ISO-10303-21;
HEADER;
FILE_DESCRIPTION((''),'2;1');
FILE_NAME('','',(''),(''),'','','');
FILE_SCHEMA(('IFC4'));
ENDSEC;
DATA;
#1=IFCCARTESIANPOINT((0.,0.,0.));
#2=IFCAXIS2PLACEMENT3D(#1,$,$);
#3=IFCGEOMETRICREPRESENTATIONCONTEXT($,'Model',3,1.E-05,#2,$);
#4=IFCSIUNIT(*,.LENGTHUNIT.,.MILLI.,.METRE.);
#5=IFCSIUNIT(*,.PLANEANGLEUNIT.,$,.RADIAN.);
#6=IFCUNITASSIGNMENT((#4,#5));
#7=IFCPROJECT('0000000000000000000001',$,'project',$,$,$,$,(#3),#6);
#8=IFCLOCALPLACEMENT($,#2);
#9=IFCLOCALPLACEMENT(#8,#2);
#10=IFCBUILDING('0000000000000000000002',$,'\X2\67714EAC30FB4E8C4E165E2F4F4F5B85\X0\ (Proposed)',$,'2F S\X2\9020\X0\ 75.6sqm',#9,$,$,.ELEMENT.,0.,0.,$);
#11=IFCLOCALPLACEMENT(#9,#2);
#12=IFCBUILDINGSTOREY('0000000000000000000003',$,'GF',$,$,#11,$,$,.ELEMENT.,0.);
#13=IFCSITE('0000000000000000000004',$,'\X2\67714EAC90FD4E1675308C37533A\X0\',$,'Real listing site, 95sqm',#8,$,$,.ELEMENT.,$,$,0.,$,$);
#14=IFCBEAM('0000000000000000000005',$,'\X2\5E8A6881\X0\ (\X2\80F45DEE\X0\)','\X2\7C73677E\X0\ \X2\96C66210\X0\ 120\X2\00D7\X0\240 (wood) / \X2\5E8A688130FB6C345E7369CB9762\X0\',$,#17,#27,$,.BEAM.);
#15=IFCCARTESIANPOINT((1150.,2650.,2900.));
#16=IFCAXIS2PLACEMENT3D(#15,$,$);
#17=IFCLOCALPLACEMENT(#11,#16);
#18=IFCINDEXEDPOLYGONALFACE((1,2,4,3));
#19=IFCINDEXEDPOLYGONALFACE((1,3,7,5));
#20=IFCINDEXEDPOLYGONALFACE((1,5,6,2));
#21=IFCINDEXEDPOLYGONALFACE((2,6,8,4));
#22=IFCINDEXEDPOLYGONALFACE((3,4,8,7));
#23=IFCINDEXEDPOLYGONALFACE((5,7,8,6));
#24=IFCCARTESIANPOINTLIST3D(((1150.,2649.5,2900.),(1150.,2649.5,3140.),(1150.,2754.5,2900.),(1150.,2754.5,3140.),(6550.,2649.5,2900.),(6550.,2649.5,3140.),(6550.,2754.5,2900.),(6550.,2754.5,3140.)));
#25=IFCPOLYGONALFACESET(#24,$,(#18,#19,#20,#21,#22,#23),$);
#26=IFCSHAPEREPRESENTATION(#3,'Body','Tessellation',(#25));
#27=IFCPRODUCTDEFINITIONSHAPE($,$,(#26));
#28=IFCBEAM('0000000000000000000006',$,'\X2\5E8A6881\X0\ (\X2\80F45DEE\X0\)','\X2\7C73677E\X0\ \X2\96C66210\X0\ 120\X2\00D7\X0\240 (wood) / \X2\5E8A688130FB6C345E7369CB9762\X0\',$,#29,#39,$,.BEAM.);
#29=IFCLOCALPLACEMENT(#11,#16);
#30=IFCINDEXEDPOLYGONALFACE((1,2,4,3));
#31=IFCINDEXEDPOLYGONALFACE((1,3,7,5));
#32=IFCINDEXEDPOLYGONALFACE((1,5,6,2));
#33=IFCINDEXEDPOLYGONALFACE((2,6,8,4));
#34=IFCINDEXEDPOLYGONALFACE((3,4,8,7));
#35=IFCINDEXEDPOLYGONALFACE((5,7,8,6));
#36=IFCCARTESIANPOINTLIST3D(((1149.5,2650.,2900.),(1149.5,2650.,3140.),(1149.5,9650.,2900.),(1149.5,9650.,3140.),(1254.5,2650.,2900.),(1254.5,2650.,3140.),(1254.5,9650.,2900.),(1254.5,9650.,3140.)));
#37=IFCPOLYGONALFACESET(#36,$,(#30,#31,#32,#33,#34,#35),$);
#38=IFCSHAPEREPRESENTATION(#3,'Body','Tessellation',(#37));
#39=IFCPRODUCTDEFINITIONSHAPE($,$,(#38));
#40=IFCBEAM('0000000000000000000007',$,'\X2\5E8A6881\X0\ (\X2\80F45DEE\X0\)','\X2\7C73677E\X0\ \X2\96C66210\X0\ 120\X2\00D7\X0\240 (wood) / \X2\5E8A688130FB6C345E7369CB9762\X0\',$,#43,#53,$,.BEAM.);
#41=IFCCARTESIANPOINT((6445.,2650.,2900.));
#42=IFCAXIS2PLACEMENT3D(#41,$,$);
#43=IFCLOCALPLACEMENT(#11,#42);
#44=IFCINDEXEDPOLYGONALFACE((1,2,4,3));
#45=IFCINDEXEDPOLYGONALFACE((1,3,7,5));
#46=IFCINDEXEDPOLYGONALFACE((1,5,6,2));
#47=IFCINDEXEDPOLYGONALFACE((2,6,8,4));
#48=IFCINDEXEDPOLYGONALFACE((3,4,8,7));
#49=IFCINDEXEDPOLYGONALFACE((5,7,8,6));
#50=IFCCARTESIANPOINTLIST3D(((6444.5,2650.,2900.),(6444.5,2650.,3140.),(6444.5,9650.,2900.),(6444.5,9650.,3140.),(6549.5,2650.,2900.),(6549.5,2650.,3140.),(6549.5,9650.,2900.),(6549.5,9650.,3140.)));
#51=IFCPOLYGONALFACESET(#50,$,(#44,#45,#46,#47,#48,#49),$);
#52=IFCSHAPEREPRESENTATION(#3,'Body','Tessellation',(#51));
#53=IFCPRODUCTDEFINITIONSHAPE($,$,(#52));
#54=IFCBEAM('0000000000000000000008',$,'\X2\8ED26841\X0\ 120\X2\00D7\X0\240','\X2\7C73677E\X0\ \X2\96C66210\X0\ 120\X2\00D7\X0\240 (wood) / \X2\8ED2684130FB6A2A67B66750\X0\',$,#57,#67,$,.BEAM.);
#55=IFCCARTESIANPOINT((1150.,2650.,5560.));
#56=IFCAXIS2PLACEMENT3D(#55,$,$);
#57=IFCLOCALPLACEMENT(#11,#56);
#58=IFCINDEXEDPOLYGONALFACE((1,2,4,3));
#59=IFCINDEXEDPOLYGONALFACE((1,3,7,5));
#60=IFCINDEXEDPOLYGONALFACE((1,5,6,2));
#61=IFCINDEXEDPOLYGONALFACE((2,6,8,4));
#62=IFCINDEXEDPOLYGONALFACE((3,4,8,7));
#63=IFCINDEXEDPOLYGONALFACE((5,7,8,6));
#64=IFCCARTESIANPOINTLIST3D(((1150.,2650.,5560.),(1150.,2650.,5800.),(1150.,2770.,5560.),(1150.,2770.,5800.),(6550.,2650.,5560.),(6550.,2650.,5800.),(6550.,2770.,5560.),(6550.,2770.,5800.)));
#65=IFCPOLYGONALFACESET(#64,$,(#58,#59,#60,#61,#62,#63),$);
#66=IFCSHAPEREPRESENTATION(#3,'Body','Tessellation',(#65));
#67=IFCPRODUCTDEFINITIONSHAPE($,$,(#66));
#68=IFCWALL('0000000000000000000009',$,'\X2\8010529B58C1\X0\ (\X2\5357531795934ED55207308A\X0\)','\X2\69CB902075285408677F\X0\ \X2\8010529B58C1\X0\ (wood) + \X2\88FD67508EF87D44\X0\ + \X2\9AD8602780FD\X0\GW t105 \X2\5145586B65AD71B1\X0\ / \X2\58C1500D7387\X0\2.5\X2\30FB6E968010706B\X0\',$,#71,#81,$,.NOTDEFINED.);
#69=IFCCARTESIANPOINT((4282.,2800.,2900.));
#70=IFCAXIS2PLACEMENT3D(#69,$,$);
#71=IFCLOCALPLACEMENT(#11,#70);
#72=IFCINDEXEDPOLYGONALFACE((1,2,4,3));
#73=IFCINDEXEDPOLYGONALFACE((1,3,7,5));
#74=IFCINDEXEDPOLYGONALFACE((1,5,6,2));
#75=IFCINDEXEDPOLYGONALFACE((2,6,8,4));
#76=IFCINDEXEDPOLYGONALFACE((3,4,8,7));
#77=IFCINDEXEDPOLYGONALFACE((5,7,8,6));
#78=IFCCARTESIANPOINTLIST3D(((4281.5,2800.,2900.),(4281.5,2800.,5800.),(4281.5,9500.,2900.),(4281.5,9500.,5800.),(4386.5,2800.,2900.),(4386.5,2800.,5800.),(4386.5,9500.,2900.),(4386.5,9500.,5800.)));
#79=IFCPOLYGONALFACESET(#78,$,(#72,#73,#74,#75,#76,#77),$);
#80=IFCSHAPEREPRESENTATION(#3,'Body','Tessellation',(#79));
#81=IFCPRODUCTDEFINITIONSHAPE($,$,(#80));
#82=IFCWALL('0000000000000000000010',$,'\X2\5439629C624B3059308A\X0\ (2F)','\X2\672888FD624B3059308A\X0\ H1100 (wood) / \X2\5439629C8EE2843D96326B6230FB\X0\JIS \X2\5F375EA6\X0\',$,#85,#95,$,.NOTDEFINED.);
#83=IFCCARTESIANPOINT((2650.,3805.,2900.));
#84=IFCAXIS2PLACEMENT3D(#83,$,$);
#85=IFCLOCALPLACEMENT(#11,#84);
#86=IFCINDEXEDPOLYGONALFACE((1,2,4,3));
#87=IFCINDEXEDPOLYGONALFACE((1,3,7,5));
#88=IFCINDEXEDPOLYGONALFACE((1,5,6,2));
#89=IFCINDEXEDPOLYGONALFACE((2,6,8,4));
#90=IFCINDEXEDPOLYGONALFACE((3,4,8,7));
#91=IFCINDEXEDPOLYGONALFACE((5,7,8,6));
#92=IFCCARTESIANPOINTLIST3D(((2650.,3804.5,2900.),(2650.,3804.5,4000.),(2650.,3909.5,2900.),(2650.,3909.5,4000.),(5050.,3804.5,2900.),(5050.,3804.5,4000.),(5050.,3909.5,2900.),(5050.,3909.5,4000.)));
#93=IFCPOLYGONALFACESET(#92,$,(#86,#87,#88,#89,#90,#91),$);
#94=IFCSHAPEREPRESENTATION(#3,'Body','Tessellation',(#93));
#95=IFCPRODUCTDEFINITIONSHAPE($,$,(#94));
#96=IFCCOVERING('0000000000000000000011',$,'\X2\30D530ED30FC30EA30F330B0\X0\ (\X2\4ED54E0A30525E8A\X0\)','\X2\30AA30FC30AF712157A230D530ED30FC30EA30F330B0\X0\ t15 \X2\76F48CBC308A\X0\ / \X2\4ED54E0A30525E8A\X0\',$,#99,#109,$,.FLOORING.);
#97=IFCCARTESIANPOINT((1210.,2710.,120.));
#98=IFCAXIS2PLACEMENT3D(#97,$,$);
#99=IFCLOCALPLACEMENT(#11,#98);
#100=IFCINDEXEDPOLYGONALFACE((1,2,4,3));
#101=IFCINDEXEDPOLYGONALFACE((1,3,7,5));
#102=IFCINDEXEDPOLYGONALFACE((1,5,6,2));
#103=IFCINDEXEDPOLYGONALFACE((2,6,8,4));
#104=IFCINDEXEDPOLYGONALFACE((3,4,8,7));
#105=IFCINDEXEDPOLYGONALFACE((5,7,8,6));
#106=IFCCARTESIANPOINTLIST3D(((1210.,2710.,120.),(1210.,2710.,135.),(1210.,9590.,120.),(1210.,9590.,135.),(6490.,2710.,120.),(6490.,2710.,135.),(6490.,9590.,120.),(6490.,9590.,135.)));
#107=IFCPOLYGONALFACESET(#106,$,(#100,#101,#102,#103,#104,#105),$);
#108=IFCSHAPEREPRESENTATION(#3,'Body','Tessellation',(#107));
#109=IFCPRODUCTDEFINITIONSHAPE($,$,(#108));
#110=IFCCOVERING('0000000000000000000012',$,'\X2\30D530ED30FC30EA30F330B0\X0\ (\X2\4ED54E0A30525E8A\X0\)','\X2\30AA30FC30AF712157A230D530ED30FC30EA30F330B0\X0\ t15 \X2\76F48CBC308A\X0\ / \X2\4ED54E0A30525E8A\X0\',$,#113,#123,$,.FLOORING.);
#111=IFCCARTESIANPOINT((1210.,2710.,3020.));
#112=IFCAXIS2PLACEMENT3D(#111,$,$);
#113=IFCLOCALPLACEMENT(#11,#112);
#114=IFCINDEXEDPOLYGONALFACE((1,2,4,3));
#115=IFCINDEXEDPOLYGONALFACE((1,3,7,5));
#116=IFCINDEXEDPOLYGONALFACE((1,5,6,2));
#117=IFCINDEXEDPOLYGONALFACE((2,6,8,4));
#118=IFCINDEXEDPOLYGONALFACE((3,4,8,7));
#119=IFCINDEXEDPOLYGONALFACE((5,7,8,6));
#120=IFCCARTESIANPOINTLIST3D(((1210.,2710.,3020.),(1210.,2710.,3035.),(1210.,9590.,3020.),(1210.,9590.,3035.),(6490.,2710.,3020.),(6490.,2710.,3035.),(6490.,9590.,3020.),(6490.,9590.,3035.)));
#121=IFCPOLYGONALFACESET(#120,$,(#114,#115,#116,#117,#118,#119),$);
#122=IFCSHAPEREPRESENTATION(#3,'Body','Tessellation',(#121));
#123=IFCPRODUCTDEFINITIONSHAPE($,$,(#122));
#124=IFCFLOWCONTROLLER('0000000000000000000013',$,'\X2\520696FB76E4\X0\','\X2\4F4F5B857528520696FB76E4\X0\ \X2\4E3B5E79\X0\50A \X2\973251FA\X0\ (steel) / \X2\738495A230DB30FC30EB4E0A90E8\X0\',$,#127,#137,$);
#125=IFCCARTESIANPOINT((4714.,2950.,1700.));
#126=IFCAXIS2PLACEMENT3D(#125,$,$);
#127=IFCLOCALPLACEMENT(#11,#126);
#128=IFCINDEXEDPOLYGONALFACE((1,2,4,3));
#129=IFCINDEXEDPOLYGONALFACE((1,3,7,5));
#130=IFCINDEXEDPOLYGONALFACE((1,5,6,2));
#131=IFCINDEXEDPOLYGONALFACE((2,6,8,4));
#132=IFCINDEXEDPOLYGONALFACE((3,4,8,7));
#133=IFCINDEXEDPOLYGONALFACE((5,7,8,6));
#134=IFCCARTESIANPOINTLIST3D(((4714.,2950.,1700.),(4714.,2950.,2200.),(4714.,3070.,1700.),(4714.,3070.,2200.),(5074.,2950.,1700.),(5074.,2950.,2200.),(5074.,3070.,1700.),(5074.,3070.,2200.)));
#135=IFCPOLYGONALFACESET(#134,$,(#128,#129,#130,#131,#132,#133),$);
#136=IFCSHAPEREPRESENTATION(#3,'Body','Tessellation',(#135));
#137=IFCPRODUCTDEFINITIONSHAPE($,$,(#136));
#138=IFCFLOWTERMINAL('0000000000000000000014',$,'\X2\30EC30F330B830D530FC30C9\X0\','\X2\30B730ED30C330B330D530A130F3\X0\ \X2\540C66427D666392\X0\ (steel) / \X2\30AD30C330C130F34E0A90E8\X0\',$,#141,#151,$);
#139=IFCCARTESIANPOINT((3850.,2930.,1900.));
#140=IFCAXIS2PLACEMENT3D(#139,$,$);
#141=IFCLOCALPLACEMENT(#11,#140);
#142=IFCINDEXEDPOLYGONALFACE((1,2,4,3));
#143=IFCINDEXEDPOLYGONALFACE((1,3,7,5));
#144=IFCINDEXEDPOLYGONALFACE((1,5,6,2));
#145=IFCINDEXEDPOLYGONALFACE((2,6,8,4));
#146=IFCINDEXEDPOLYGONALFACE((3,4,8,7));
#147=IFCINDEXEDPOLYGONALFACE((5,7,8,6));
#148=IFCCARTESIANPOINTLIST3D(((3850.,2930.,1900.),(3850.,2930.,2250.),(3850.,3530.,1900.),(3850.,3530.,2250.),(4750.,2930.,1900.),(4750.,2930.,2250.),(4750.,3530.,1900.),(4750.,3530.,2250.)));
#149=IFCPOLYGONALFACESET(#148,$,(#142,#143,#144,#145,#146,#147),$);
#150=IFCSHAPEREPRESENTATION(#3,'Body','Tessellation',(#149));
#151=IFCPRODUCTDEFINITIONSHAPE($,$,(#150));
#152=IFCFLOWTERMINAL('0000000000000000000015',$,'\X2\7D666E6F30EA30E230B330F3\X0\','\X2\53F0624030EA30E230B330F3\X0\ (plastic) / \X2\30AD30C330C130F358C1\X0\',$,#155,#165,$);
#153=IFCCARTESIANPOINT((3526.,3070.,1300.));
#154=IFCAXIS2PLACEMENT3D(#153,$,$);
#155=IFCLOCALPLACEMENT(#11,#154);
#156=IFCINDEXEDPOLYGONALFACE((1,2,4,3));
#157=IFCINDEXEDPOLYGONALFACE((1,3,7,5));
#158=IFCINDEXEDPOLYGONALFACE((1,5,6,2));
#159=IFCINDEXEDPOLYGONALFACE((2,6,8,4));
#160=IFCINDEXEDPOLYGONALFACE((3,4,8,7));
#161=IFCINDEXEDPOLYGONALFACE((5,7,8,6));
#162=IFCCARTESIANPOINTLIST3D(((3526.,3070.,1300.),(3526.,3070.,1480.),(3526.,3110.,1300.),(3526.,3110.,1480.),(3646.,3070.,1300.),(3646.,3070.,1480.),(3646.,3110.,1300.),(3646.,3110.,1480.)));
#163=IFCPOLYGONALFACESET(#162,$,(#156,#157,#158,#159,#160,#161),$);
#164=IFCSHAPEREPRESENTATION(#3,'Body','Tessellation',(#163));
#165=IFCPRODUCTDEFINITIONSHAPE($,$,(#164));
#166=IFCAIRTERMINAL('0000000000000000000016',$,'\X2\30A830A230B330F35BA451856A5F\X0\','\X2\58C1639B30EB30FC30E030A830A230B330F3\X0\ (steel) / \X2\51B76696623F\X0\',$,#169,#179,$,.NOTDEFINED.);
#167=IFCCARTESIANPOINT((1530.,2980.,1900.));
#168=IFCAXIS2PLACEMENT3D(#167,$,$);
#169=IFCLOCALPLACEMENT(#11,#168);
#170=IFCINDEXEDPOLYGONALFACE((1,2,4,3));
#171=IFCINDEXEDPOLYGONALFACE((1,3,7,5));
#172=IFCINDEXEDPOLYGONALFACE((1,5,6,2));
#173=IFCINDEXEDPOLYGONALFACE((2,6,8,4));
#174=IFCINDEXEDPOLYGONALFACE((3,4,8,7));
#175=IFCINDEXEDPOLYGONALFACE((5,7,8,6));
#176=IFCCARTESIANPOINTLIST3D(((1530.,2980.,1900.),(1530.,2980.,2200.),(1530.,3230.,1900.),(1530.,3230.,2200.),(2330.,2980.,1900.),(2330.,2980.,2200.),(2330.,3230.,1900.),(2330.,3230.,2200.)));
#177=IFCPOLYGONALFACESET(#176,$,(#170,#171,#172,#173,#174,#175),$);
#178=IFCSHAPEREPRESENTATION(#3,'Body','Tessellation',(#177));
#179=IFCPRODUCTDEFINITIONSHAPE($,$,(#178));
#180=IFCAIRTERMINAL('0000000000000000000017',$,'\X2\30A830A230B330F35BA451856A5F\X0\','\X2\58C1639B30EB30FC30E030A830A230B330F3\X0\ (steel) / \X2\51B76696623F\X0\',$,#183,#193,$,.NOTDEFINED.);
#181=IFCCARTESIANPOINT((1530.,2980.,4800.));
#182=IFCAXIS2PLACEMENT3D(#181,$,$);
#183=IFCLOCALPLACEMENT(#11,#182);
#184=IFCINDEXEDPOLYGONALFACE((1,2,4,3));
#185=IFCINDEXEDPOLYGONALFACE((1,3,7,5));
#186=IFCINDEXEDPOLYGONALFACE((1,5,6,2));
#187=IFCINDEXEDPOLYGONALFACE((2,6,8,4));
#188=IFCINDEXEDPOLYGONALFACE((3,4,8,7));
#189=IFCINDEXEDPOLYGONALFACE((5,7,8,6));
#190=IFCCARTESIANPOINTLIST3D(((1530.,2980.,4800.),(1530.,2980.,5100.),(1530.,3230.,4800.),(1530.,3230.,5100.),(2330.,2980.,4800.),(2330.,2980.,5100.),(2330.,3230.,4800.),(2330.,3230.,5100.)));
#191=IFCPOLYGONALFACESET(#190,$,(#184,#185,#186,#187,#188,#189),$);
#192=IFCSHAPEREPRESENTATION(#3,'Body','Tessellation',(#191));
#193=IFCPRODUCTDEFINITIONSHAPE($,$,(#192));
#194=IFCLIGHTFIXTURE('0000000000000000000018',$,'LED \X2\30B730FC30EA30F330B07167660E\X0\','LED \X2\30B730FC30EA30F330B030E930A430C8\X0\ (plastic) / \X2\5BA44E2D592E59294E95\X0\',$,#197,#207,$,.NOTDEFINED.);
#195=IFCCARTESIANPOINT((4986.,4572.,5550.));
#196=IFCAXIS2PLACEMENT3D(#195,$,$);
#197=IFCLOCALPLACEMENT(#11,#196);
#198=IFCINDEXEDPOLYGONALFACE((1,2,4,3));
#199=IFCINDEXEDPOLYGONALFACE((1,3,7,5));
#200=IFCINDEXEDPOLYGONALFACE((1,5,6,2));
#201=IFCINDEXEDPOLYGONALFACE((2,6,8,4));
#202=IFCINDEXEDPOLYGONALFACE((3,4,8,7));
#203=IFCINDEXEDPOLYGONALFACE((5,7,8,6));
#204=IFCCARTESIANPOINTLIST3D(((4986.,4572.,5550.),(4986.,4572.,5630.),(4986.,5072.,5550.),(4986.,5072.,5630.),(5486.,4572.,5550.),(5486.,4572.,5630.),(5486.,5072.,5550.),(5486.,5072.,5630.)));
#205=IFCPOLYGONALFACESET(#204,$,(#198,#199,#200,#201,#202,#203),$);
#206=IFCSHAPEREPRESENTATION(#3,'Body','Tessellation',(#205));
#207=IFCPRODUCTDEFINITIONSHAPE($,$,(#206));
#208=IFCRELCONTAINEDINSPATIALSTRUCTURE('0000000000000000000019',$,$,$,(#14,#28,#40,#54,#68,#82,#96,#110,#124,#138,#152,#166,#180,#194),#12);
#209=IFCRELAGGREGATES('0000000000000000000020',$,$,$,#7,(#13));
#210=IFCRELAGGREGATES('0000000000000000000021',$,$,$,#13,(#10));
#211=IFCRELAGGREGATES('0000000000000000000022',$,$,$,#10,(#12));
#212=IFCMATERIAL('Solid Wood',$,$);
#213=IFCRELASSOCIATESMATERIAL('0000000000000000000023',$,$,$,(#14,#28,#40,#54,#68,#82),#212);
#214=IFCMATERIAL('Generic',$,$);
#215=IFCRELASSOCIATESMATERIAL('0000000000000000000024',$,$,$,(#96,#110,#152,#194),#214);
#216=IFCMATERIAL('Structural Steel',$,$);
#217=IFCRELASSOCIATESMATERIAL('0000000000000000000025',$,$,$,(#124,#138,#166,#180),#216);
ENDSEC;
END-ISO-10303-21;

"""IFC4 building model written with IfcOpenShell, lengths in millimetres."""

from ifc_helpers import new_model, si_unit, frame, frame_2d, origin, place, context, project, spatial, rectangle, extrude, material, element, save


model = new_model("IFC4")

# Units and contexts
model_context = context("Model", 3, precision=1e-05, world=origin())
ifc_project = project(units=[si_unit("LENGTHUNIT", "METRE", prefix="MILLI"), si_unit("PLANEANGLEUNIT", "RADIAN")], contexts=[model_context])

# Site, building, storey
site_placement = place(None, origin())
site = spatial("IfcSite", under=ifc_project, at=site_placement, Name="東京都世田谷区", ObjectType="Real listing site, 95sqm", CompositionType="ELEMENT", RefElevation=0.0)
building_placement = place(site_placement, origin())
building = spatial("IfcBuilding", under=site, at=building_placement, Name="東京・二世帯住宅 (Proposed)", ObjectType="2F S造 75.6sqm", CompositionType="ELEMENT", ElevationOfRefHeight=0.0, ElevationOfTerrain=0.0)
storey_placement = place(building_placement, origin())
storey = spatial("IfcBuildingStorey", under=building, at=storey_placement, Name="GF", CompositionType="ELEMENT", Elevation=0.0)

# Shared definitions
ifc_material_1 = material(Name="Solid Wood")

# Beams
beam_1_placement = place(storey_placement, frame((1150.0, 2650.0, 2900.0)))
element("IfcBeam", 1, at=beam_1_placement, inside=storey, material=ifc_material_1, Name="床梁 (胴差)", Description="米松 集成 120×240 (wood) / 床梁・水平構面", PredefinedType="BEAM", context=model_context, shape_type="SweptSolid", body=[
    extrude(rectangle(XDim=5400.0, YDim=105.0, at=frame_2d((2700.0, 52.0))), frame((1150.0, 2650.0, 2900.0)), (0.0, 0.0, 1.0), 240.0),
])
beam_2_placement = place(storey_placement, frame((1150.0, 2650.0, 2900.0)))
element("IfcBeam", 2, at=beam_2_placement, inside=storey, material=ifc_material_1, Name="床梁 (胴差)", Description="米松 集成 120×240 (wood) / 床梁・水平構面", PredefinedType="BEAM", context=model_context, shape_type="SweptSolid", body=[
    extrude(rectangle(XDim=105.0, YDim=7000.0, at=frame_2d((52.0, 3500.0))), frame((1150.0, 2650.0, 2900.0)), (0.0, 0.0, 1.0), 240.0),
])
beam_3_placement = place(storey_placement, frame((6445.0, 2650.0, 2900.0)))
element("IfcBeam", 3, at=beam_3_placement, inside=storey, material=ifc_material_1, Name="床梁 (胴差)", Description="米松 集成 120×240 (wood) / 床梁・水平構面", PredefinedType="BEAM", context=model_context, shape_type="SweptSolid", body=[
    extrude(rectangle(XDim=105.0, YDim=7000.0, at=frame_2d((52.0, 3500.0))), frame((6445.0, 2650.0, 2900.0)), (0.0, 0.0, 1.0), 240.0),
])
beam_4_placement = place(storey_placement, frame((1150.0, 2650.0, 5560.0)))
element("IfcBeam", 4, at=beam_4_placement, inside=storey, material=ifc_material_1, Name="軒桁 120×240", Description="米松 集成 120×240 (wood) / 軒桁・横架材", PredefinedType="BEAM", context=model_context, shape_type="SweptSolid", body=[
    extrude(rectangle(XDim=5400.0, YDim=120.0, at=frame_2d((2700.0, 60.0))), frame((1150.0, 2650.0, 5560.0)), (0.0, 0.0, 1.0), 240.0),
])

# Walls
wall_1_placement = place(storey_placement, frame((4282.0, 2800.0, 2900.0)))
element("IfcWall", 5, at=wall_1_placement, inside=storey, material=ifc_material_1, Name="耐力壁 (南北間仕切り)", Description="構造用合板 耐力壁 (wood) + 製材軸組 + 高性能GW t105 充填断熱 / 壁倍率2.5・準耐火", PredefinedType="NOTDEFINED", context=model_context, shape_type="SweptSolid", body=[
    extrude(rectangle(XDim=105.0, YDim=6700.0, at=frame_2d((52.0, 3350.0))), frame((4282.0, 2800.0, 2900.0)), (0.0, 0.0, 1.0), 2900.0),
])
wall_2_placement = place(storey_placement, frame((2650.0, 3805.0, 2900.0)))
element("IfcWall", 6, at=wall_2_placement, inside=storey, material=ifc_material_1, Name="吹抜手すり (2F)", Description="木製手すり H1100 (wood) / 吹抜転落防止・JIS 強度", PredefinedType="NOTDEFINED", context=model_context, shape_type="SweptSolid", body=[
    extrude(rectangle(XDim=2400.0, YDim=105.0, at=frame_2d((1200.0, 52.0))), frame((2650.0, 3805.0, 2900.0)), (0.0, 0.0, 1.0), 1100.0),
])

# Coverings
ifc_material_2 = material(Name="Generic")
covering_1_placement = place(storey_placement, frame((1210.0, 2710.0, 120.0)))
element("IfcCovering", 7, at=covering_1_placement, inside=storey, material=ifc_material_2, Name="フローリング (仕上げ床)", Description="オーク無垢フローリング t15 直貼り / 仕上げ床", PredefinedType="FLOORING", context=model_context, shape_type="SweptSolid", body=[
    extrude(rectangle(XDim=5280.0, YDim=6880.0, at=frame_2d((2640.0, 3440.0))), frame((1210.0, 2710.0, 120.0)), (0.0, 0.0, 1.0), 15.0),
])
covering_2_placement = place(storey_placement, frame((1210.0, 2710.0, 3020.0)))
element("IfcCovering", 8, at=covering_2_placement, inside=storey, material=ifc_material_2, Name="フローリング (仕上げ床)", Description="オーク無垢フローリング t15 直貼り / 仕上げ床", PredefinedType="FLOORING", context=model_context, shape_type="SweptSolid", body=[
    extrude(rectangle(XDim=5280.0, YDim=6880.0, at=frame_2d((2640.0, 3440.0))), frame((1210.0, 2710.0, 3020.0)), (0.0, 0.0, 1.0), 15.0),
])

# Flow controller
ifc_material_3 = material(Name="Structural Steel")
flow_controller_placement = place(storey_placement, frame((4714.0, 2950.0, 1700.0)))
element("IfcFlowController", 9, at=flow_controller_placement, inside=storey, material=ifc_material_3, Name="分電盤", Description="住宅用分電盤 主幹50A 露出 (steel) / 玄関ホール上部", context=model_context, shape_type="SweptSolid", body=[
    extrude(rectangle(XDim=360.0, YDim=120.0, at=frame_2d((180.0, 60.0))), frame((4714.0, 2950.0, 1700.0)), (0.0, 0.0, 1.0), 500.0),
])

# Flow terminals
flow_terminal_1_placement = place(storey_placement, frame((3850.0, 2930.0, 1900.0)))
element("IfcFlowTerminal", 10, at=flow_terminal_1_placement, inside=storey, material=ifc_material_3, Name="レンジフード", Description="シロッコファン 同時給排 (steel) / キッチン上部", context=model_context, shape_type="SweptSolid", body=[
    extrude(rectangle(XDim=900.0, YDim=600.0, at=frame_2d((450.0, 300.0))), frame((3850.0, 2930.0, 1900.0)), (0.0, 0.0, 1.0), 350.0),
])
flow_terminal_2_placement = place(storey_placement, frame((3526.0, 3070.0, 1300.0)))
element("IfcFlowTerminal", 11, at=flow_terminal_2_placement, inside=storey, material=ifc_material_2, Name="給湯リモコン", Description="台所リモコン (plastic) / キッチン壁", context=model_context, shape_type="SweptSolid", body=[
    extrude(rectangle(XDim=120.0, YDim=40.0, at=frame_2d((60.0, 20.0))), frame((3526.0, 3070.0, 1300.0)), (0.0, 0.0, 1.0), 180.0),
])

# Air terminals
air_terminal_1_placement = place(storey_placement, frame((1530.0, 2980.0, 1900.0)))
element("IfcAirTerminal", 12, at=air_terminal_1_placement, inside=storey, material=ifc_material_3, Name="エアコン室内機", Description="壁掛ルームエアコン (steel) / 冷暖房", PredefinedType="NOTDEFINED", context=model_context, shape_type="SweptSolid", body=[
    extrude(rectangle(XDim=800.0, YDim=250.0, at=frame_2d((400.0, 125.0))), frame((1530.0, 2980.0, 1900.0)), (0.0, 0.0, 1.0), 300.0),
])
air_terminal_2_placement = place(storey_placement, frame((1530.0, 2980.0, 4800.0)))
element("IfcAirTerminal", 13, at=air_terminal_2_placement, inside=storey, material=ifc_material_3, Name="エアコン室内機", Description="壁掛ルームエアコン (steel) / 冷暖房", PredefinedType="NOTDEFINED", context=model_context, shape_type="SweptSolid", body=[
    extrude(rectangle(XDim=800.0, YDim=250.0, at=frame_2d((400.0, 125.0))), frame((1530.0, 2980.0, 4800.0)), (0.0, 0.0, 1.0), 300.0),
])

# Light fixture
light_fixture_placement = place(storey_placement, frame((4986.0, 4572.0, 5550.0)))
element("IfcLightFixture", 14, at=light_fixture_placement, inside=storey, material=ifc_material_2, Name="LED シーリング照明", Description="LED シーリングライト (plastic) / 室中央天井", PredefinedType="NOTDEFINED", context=model_context, shape_type="SweptSolid", body=[
    extrude(rectangle(XDim=500.0, YDim=500.0, at=frame_2d((250.0, 250.0))), frame((4986.0, 4572.0, 5550.0)), (0.0, 0.0, 1.0), 80.0),
])

save(model, "model.ifc")
